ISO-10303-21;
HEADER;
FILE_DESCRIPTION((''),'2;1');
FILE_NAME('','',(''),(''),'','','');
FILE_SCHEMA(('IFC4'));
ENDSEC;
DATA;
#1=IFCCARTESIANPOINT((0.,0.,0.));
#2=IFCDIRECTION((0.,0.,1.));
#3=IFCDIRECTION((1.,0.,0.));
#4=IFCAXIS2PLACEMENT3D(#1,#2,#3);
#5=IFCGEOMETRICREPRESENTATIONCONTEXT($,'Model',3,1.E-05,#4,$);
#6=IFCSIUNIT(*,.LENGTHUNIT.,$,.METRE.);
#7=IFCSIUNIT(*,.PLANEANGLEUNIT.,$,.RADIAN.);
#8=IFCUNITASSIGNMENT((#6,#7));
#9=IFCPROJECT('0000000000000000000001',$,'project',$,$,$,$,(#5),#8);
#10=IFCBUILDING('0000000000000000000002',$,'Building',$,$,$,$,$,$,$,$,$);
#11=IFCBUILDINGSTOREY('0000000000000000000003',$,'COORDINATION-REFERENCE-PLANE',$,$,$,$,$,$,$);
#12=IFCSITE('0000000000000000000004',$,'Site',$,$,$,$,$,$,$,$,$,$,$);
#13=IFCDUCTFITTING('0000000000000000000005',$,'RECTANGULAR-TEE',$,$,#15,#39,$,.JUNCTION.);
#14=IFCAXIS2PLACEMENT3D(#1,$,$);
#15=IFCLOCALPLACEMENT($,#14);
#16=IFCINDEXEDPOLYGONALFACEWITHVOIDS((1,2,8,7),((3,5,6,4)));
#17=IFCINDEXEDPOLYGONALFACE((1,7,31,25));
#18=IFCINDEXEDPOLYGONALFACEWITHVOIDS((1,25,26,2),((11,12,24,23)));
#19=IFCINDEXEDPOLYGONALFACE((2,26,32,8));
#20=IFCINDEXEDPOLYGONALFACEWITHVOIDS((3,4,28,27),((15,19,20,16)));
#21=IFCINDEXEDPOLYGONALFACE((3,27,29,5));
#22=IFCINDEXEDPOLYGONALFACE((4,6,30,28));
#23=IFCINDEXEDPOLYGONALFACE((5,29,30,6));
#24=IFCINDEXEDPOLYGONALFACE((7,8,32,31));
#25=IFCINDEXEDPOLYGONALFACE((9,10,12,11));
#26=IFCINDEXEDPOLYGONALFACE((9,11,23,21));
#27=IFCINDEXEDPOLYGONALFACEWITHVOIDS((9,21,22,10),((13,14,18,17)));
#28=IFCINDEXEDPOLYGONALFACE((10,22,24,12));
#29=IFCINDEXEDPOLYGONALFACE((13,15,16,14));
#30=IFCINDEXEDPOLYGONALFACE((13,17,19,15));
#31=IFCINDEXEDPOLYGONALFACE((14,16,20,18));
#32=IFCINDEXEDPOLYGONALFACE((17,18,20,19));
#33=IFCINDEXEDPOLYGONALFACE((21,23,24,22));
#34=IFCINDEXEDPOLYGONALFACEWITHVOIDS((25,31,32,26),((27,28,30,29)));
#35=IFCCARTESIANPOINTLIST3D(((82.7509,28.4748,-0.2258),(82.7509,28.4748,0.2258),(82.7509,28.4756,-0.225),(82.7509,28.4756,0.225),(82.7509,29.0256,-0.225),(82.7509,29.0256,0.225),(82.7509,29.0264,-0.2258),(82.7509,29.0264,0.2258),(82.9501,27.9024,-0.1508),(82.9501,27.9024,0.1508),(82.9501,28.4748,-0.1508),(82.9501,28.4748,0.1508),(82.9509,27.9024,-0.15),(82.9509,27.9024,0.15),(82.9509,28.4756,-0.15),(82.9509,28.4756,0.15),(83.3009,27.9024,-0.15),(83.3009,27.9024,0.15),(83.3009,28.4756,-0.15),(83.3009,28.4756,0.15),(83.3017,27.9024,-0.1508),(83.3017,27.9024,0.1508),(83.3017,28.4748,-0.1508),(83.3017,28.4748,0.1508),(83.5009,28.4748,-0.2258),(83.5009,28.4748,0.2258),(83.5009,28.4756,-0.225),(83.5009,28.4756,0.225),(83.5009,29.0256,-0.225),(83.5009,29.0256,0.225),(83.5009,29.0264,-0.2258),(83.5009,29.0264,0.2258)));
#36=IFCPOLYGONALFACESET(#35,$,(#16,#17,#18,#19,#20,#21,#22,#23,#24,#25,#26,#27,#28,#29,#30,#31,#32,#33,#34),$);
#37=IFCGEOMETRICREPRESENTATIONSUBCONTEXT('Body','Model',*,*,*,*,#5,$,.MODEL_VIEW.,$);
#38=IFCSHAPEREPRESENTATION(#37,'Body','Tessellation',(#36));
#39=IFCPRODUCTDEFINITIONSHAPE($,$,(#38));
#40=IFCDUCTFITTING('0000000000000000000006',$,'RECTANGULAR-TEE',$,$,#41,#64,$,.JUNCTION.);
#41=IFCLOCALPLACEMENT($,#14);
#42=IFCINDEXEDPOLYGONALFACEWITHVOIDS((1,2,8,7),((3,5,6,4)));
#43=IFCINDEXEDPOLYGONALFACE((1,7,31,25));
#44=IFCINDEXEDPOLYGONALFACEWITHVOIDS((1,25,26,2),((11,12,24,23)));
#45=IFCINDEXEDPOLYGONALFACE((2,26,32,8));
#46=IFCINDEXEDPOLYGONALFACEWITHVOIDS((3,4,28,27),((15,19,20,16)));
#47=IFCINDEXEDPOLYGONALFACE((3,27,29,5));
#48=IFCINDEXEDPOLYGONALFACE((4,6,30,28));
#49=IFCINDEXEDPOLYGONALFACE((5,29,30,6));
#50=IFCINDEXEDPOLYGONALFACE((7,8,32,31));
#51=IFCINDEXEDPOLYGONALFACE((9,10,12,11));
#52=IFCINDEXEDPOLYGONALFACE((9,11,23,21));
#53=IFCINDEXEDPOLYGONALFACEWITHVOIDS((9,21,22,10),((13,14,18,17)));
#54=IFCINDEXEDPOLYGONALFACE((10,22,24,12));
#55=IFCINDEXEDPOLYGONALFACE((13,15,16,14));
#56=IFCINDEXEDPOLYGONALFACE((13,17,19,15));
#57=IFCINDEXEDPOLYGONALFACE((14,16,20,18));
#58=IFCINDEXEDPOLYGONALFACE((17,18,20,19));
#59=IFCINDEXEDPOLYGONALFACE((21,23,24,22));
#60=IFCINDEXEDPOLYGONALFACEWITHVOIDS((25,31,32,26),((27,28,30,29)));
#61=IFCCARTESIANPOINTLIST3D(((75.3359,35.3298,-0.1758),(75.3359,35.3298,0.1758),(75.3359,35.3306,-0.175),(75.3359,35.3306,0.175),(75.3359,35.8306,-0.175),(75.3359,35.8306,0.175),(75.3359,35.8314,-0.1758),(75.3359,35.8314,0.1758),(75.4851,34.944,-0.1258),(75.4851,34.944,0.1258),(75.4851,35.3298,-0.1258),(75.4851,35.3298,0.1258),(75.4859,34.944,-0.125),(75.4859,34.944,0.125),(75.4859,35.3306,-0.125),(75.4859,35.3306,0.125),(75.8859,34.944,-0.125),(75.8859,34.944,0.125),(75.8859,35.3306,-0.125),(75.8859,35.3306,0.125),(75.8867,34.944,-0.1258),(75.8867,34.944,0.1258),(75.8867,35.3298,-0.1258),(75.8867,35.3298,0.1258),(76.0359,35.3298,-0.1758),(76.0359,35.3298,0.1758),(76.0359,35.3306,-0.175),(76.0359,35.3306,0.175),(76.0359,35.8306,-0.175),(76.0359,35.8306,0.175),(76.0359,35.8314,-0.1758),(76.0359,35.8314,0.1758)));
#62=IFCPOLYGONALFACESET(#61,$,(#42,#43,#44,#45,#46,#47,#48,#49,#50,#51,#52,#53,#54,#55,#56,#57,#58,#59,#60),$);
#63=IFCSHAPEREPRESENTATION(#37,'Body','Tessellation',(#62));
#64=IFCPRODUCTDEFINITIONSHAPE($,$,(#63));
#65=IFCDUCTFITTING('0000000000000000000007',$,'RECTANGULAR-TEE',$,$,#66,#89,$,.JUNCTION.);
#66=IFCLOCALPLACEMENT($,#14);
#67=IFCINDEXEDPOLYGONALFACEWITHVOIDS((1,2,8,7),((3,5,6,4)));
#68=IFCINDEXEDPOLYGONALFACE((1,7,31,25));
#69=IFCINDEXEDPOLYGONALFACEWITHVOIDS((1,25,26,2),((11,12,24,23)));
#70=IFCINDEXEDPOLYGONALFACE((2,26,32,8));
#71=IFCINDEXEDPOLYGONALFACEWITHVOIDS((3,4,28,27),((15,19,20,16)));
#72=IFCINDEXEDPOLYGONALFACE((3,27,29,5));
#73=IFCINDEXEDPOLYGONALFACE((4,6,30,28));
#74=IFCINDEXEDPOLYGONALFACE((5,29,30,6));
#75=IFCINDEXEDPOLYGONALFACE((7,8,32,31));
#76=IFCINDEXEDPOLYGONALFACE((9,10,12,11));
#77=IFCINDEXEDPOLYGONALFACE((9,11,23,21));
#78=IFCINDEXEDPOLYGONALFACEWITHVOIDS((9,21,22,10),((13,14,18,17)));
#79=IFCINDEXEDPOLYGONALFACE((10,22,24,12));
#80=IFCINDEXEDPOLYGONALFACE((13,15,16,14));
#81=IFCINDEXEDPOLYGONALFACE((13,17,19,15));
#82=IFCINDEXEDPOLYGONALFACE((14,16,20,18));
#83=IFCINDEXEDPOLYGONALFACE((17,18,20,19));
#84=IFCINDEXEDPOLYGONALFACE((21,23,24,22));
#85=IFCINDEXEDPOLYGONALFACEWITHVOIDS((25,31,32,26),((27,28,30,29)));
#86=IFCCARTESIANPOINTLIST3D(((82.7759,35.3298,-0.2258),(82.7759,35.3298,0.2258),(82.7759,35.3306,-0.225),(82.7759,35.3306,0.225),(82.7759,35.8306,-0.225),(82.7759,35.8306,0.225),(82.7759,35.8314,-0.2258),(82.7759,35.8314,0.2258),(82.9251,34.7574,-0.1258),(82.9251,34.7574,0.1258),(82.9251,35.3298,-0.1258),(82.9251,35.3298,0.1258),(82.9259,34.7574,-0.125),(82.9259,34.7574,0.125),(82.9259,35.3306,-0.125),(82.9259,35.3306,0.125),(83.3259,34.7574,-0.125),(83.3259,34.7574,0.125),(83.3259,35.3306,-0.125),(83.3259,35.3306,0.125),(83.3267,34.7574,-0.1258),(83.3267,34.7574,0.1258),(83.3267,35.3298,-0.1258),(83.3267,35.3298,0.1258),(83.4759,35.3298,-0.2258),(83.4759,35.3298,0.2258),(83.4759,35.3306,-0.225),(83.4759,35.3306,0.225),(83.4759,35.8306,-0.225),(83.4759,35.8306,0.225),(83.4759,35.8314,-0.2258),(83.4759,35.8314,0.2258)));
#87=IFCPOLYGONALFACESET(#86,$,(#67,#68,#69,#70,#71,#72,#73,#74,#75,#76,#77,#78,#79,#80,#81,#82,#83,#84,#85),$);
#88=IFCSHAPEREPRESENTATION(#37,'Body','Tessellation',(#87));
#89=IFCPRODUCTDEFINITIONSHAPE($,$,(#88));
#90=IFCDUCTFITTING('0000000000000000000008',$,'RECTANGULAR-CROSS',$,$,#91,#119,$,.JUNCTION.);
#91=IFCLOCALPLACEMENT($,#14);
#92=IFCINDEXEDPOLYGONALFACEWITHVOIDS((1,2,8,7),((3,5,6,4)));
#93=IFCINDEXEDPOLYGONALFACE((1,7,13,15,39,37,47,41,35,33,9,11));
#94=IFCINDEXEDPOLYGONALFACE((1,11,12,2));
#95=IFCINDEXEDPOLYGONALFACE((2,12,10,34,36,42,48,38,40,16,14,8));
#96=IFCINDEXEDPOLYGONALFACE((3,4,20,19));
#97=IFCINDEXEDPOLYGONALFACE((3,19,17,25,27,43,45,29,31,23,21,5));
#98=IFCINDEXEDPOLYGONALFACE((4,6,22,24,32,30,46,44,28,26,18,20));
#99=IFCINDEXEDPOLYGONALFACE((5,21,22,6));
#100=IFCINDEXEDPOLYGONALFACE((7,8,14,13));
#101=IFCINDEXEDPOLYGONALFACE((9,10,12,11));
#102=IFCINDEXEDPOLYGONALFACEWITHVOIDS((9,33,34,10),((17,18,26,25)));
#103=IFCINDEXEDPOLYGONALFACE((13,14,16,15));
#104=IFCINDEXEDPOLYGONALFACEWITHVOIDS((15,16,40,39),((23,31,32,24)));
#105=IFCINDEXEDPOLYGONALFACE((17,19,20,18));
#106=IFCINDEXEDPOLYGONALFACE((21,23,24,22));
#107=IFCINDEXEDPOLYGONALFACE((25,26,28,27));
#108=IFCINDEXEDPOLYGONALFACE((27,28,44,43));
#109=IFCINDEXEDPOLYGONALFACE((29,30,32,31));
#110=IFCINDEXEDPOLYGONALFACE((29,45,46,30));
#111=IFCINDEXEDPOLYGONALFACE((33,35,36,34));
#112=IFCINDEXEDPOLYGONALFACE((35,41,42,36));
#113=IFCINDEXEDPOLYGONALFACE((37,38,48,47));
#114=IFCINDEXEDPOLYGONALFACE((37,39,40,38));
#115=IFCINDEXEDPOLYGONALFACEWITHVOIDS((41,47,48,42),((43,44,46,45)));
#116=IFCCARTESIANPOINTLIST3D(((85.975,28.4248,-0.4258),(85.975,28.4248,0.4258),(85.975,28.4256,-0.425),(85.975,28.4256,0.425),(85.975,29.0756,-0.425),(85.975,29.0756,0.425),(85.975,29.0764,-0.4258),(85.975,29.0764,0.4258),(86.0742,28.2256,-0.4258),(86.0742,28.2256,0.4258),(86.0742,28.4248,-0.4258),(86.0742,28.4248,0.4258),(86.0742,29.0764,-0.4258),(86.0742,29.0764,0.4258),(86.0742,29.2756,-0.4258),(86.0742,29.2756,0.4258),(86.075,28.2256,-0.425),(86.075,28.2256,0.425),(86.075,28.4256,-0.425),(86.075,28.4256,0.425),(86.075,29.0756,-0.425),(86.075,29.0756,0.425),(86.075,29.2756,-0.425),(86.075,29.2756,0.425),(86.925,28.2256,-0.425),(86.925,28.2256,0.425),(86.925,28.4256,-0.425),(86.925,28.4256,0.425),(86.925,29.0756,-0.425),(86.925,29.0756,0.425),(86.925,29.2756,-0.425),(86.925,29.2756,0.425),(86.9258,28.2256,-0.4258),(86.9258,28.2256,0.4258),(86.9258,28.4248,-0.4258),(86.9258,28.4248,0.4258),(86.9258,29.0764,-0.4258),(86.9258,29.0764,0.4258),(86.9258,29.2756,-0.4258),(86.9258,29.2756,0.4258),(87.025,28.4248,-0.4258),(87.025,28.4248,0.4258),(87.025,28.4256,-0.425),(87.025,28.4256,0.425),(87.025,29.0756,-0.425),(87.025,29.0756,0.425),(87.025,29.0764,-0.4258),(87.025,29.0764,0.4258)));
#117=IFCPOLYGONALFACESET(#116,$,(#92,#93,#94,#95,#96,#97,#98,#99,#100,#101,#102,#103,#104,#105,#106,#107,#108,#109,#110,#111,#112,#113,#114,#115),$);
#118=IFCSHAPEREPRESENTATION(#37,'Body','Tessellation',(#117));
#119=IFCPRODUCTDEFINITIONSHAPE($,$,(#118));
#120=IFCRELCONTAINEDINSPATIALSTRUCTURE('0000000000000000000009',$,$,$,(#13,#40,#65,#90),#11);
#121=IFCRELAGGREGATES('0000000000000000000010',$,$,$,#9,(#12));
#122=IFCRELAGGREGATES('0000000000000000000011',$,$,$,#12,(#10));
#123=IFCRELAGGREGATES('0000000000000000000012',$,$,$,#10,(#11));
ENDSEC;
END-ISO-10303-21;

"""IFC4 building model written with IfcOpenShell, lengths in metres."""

from ifc_helpers import new_model, si_unit, frame, origin_with_axes, place, context, subcontext, project, spatial, rectangle, extrude, boolean, element, save


model = new_model("IFC4")

# Units and contexts
model_context = context("Model", 3, precision=1e-05, world=origin_with_axes())
body_context = subcontext(model_context, "Body", "Model", "MODEL_VIEW")
ifc_project = project(units=[si_unit("LENGTHUNIT", "METRE"), si_unit("PLANEANGLEUNIT", "RADIAN")], contexts=[model_context])

# Site, building, storey
site = spatial("IfcSite", under=ifc_project, Name="Site")
building = spatial("IfcBuilding", under=site, Name="Building")
storey = spatial("IfcBuildingStorey", under=building, Name="COORDINATION-REFERENCE-PLANE")

# Duct fittings
duct_fitting_1_placement = place(None, frame((83.1259, 28.7506, 0.0), z_axis=(-1.0, 0.0, 0.0), x_axis=(0.0, -1.0, 0.0)))
solid_1 = boolean("UNION", extrude(rectangle(XDim=0.55, YDim=0.45), frame((0.0, 0.0, -0.375), z_axis=(0.0, 0.0, 1.0), x_axis=(1.0, 0.0, 0.0)), (0.0, 0.0, 1.0), 0.75), extrude(rectangle(XDim=0.35, YDim=0.3), frame((0.0, 0.0, 0.0), z_axis=(1.0, 0.0, 0.0), x_axis=(0.0, 0.0, -1.0)), (0.0, 0.0, 1.0), 0.8482))
element("IfcDuctFitting", 1, at=duct_fitting_1_placement, inside=storey, Name="RECTANGULAR-TEE", PredefinedType="JUNCTION", context=body_context, shape_type="CSG", body=[
    boolean("DIFFERENCE", boolean("UNION", extrude(rectangle(XDim=0.5516, YDim=0.4516), frame((0.0, 0.0, -0.375), z_axis=(0.0, 0.0, 1.0), x_axis=(1.0, 0.0, 0.0)), (0.0, 0.0, 1.0), 0.75), extrude(rectangle(XDim=0.3516, YDim=0.3016), frame((0.0, 0.0, 0.0), z_axis=(1.0, 0.0, 0.0), x_axis=(0.0, 0.0, -1.0)), (0.0, 0.0, 1.0), 0.8482)), solid_1),
])
duct_fitting_2_placement = place(None, frame((75.6859, 35.5806, 0.0), z_axis=(-1.0, 0.0, 0.0), x_axis=(0.0, -1.0, 0.0)))
solid_2 = boolean("UNION", extrude(rectangle(XDim=0.5, YDim=0.35), frame((0.0, 0.0, -0.35), z_axis=(0.0, 0.0, 1.0), x_axis=(1.0, 0.0, 0.0)), (0.0, 0.0, 1.0), 0.7), extrude(rectangle(XDim=0.4, YDim=0.25), frame((0.0, 0.0, 0.0), z_axis=(1.0, 0.0, 0.0), x_axis=(0.0, 0.0, -1.0)), (0.0, 0.0, 1.0), 0.6366))
element("IfcDuctFitting", 2, at=duct_fitting_2_placement, inside=storey, Name="RECTANGULAR-TEE", PredefinedType="JUNCTION", context=body_context, shape_type="CSG", body=[
    boolean("DIFFERENCE", boolean("UNION", extrude(rectangle(XDim=0.5016, YDim=0.3516), frame((0.0, 0.0, -0.35), z_axis=(0.0, 0.0, 1.0), x_axis=(1.0, 0.0, 0.0)), (0.0, 0.0, 1.0), 0.7), extrude(rectangle(XDim=0.4016, YDim=0.2516), frame((0.0, 0.0, 0.0), z_axis=(1.0, 0.0, 0.0), x_axis=(0.0, 0.0, -1.0)), (0.0, 0.0, 1.0), 0.6366)), solid_2),
])
duct_fitting_3_placement = place(None, frame((83.1259, 35.5806, 0.0), z_axis=(-1.0, 0.0, 0.0), x_axis=(0.0, -1.0, 0.0)))
solid_3 = boolean("UNION", extrude(rectangle(XDim=0.5, YDim=0.45), frame((0.0, 0.0, -0.35), z_axis=(0.0, 0.0, 1.0), x_axis=(1.0, 0.0, 0.0)), (0.0, 0.0, 1.0), 0.7), extrude(rectangle(XDim=0.4, YDim=0.25), frame((0.0, 0.0, 0.0), z_axis=(1.0, 0.0, 0.0), x_axis=(0.0, 0.0, -1.0)), (0.0, 0.0, 1.0), 0.8232))
element("IfcDuctFitting", 3, at=duct_fitting_3_placement, inside=storey, Name="RECTANGULAR-TEE", PredefinedType="JUNCTION", context=body_context, shape_type="CSG", body=[
    boolean("DIFFERENCE", boolean("UNION", extrude(rectangle(XDim=0.5016, YDim=0.4516), frame((0.0, 0.0, -0.35), z_axis=(0.0, 0.0, 1.0), x_axis=(1.0, 0.0, 0.0)), (0.0, 0.0, 1.0), 0.7), extrude(rectangle(XDim=0.4016, YDim=0.2516), frame((0.0, 0.0, 0.0), z_axis=(1.0, 0.0, 0.0), x_axis=(0.0, 0.0, -1.0)), (0.0, 0.0, 1.0), 0.8232)), solid_3),
])
duct_fitting_4_placement = place(None, frame((86.5, 28.7506, 0.0), z_axis=(0.0, -1.0, 0.0), x_axis=(1.0, 0.0, 0.0)))
solid_4 = boolean("UNION", extrude(rectangle(XDim=0.85, YDim=0.85), frame((0.0, 0.0, -0.525), z_axis=(0.0, 0.0, 1.0), x_axis=(1.0, 0.0, 0.0)), (0.0, 0.0, 1.0), 1.05), extrude(rectangle(XDim=0.65, YDim=0.85), frame((-0.525, 0.0, 0.0), z_axis=(1.0, 0.0, 0.0), x_axis=(0.0, 0.0, -1.0)), (0.0, 0.0, 1.0), 1.05))
element("IfcDuctFitting", 4, at=duct_fitting_4_placement, inside=storey, Name="RECTANGULAR-CROSS", PredefinedType="JUNCTION", context=body_context, shape_type="CSG", body=[
    boolean("DIFFERENCE", boolean("UNION", extrude(rectangle(XDim=0.8516, YDim=0.8516), frame((0.0, 0.0, -0.525), z_axis=(0.0, 0.0, 1.0), x_axis=(1.0, 0.0, 0.0)), (0.0, 0.0, 1.0), 1.05), extrude(rectangle(XDim=0.6516, YDim=0.8516), frame((-0.525, 0.0, 0.0), z_axis=(1.0, 0.0, 0.0), x_axis=(0.0, 0.0, -1.0)), (0.0, 0.0, 1.0), 1.05)), solid_4),
])

save(model, "model.ifc")
